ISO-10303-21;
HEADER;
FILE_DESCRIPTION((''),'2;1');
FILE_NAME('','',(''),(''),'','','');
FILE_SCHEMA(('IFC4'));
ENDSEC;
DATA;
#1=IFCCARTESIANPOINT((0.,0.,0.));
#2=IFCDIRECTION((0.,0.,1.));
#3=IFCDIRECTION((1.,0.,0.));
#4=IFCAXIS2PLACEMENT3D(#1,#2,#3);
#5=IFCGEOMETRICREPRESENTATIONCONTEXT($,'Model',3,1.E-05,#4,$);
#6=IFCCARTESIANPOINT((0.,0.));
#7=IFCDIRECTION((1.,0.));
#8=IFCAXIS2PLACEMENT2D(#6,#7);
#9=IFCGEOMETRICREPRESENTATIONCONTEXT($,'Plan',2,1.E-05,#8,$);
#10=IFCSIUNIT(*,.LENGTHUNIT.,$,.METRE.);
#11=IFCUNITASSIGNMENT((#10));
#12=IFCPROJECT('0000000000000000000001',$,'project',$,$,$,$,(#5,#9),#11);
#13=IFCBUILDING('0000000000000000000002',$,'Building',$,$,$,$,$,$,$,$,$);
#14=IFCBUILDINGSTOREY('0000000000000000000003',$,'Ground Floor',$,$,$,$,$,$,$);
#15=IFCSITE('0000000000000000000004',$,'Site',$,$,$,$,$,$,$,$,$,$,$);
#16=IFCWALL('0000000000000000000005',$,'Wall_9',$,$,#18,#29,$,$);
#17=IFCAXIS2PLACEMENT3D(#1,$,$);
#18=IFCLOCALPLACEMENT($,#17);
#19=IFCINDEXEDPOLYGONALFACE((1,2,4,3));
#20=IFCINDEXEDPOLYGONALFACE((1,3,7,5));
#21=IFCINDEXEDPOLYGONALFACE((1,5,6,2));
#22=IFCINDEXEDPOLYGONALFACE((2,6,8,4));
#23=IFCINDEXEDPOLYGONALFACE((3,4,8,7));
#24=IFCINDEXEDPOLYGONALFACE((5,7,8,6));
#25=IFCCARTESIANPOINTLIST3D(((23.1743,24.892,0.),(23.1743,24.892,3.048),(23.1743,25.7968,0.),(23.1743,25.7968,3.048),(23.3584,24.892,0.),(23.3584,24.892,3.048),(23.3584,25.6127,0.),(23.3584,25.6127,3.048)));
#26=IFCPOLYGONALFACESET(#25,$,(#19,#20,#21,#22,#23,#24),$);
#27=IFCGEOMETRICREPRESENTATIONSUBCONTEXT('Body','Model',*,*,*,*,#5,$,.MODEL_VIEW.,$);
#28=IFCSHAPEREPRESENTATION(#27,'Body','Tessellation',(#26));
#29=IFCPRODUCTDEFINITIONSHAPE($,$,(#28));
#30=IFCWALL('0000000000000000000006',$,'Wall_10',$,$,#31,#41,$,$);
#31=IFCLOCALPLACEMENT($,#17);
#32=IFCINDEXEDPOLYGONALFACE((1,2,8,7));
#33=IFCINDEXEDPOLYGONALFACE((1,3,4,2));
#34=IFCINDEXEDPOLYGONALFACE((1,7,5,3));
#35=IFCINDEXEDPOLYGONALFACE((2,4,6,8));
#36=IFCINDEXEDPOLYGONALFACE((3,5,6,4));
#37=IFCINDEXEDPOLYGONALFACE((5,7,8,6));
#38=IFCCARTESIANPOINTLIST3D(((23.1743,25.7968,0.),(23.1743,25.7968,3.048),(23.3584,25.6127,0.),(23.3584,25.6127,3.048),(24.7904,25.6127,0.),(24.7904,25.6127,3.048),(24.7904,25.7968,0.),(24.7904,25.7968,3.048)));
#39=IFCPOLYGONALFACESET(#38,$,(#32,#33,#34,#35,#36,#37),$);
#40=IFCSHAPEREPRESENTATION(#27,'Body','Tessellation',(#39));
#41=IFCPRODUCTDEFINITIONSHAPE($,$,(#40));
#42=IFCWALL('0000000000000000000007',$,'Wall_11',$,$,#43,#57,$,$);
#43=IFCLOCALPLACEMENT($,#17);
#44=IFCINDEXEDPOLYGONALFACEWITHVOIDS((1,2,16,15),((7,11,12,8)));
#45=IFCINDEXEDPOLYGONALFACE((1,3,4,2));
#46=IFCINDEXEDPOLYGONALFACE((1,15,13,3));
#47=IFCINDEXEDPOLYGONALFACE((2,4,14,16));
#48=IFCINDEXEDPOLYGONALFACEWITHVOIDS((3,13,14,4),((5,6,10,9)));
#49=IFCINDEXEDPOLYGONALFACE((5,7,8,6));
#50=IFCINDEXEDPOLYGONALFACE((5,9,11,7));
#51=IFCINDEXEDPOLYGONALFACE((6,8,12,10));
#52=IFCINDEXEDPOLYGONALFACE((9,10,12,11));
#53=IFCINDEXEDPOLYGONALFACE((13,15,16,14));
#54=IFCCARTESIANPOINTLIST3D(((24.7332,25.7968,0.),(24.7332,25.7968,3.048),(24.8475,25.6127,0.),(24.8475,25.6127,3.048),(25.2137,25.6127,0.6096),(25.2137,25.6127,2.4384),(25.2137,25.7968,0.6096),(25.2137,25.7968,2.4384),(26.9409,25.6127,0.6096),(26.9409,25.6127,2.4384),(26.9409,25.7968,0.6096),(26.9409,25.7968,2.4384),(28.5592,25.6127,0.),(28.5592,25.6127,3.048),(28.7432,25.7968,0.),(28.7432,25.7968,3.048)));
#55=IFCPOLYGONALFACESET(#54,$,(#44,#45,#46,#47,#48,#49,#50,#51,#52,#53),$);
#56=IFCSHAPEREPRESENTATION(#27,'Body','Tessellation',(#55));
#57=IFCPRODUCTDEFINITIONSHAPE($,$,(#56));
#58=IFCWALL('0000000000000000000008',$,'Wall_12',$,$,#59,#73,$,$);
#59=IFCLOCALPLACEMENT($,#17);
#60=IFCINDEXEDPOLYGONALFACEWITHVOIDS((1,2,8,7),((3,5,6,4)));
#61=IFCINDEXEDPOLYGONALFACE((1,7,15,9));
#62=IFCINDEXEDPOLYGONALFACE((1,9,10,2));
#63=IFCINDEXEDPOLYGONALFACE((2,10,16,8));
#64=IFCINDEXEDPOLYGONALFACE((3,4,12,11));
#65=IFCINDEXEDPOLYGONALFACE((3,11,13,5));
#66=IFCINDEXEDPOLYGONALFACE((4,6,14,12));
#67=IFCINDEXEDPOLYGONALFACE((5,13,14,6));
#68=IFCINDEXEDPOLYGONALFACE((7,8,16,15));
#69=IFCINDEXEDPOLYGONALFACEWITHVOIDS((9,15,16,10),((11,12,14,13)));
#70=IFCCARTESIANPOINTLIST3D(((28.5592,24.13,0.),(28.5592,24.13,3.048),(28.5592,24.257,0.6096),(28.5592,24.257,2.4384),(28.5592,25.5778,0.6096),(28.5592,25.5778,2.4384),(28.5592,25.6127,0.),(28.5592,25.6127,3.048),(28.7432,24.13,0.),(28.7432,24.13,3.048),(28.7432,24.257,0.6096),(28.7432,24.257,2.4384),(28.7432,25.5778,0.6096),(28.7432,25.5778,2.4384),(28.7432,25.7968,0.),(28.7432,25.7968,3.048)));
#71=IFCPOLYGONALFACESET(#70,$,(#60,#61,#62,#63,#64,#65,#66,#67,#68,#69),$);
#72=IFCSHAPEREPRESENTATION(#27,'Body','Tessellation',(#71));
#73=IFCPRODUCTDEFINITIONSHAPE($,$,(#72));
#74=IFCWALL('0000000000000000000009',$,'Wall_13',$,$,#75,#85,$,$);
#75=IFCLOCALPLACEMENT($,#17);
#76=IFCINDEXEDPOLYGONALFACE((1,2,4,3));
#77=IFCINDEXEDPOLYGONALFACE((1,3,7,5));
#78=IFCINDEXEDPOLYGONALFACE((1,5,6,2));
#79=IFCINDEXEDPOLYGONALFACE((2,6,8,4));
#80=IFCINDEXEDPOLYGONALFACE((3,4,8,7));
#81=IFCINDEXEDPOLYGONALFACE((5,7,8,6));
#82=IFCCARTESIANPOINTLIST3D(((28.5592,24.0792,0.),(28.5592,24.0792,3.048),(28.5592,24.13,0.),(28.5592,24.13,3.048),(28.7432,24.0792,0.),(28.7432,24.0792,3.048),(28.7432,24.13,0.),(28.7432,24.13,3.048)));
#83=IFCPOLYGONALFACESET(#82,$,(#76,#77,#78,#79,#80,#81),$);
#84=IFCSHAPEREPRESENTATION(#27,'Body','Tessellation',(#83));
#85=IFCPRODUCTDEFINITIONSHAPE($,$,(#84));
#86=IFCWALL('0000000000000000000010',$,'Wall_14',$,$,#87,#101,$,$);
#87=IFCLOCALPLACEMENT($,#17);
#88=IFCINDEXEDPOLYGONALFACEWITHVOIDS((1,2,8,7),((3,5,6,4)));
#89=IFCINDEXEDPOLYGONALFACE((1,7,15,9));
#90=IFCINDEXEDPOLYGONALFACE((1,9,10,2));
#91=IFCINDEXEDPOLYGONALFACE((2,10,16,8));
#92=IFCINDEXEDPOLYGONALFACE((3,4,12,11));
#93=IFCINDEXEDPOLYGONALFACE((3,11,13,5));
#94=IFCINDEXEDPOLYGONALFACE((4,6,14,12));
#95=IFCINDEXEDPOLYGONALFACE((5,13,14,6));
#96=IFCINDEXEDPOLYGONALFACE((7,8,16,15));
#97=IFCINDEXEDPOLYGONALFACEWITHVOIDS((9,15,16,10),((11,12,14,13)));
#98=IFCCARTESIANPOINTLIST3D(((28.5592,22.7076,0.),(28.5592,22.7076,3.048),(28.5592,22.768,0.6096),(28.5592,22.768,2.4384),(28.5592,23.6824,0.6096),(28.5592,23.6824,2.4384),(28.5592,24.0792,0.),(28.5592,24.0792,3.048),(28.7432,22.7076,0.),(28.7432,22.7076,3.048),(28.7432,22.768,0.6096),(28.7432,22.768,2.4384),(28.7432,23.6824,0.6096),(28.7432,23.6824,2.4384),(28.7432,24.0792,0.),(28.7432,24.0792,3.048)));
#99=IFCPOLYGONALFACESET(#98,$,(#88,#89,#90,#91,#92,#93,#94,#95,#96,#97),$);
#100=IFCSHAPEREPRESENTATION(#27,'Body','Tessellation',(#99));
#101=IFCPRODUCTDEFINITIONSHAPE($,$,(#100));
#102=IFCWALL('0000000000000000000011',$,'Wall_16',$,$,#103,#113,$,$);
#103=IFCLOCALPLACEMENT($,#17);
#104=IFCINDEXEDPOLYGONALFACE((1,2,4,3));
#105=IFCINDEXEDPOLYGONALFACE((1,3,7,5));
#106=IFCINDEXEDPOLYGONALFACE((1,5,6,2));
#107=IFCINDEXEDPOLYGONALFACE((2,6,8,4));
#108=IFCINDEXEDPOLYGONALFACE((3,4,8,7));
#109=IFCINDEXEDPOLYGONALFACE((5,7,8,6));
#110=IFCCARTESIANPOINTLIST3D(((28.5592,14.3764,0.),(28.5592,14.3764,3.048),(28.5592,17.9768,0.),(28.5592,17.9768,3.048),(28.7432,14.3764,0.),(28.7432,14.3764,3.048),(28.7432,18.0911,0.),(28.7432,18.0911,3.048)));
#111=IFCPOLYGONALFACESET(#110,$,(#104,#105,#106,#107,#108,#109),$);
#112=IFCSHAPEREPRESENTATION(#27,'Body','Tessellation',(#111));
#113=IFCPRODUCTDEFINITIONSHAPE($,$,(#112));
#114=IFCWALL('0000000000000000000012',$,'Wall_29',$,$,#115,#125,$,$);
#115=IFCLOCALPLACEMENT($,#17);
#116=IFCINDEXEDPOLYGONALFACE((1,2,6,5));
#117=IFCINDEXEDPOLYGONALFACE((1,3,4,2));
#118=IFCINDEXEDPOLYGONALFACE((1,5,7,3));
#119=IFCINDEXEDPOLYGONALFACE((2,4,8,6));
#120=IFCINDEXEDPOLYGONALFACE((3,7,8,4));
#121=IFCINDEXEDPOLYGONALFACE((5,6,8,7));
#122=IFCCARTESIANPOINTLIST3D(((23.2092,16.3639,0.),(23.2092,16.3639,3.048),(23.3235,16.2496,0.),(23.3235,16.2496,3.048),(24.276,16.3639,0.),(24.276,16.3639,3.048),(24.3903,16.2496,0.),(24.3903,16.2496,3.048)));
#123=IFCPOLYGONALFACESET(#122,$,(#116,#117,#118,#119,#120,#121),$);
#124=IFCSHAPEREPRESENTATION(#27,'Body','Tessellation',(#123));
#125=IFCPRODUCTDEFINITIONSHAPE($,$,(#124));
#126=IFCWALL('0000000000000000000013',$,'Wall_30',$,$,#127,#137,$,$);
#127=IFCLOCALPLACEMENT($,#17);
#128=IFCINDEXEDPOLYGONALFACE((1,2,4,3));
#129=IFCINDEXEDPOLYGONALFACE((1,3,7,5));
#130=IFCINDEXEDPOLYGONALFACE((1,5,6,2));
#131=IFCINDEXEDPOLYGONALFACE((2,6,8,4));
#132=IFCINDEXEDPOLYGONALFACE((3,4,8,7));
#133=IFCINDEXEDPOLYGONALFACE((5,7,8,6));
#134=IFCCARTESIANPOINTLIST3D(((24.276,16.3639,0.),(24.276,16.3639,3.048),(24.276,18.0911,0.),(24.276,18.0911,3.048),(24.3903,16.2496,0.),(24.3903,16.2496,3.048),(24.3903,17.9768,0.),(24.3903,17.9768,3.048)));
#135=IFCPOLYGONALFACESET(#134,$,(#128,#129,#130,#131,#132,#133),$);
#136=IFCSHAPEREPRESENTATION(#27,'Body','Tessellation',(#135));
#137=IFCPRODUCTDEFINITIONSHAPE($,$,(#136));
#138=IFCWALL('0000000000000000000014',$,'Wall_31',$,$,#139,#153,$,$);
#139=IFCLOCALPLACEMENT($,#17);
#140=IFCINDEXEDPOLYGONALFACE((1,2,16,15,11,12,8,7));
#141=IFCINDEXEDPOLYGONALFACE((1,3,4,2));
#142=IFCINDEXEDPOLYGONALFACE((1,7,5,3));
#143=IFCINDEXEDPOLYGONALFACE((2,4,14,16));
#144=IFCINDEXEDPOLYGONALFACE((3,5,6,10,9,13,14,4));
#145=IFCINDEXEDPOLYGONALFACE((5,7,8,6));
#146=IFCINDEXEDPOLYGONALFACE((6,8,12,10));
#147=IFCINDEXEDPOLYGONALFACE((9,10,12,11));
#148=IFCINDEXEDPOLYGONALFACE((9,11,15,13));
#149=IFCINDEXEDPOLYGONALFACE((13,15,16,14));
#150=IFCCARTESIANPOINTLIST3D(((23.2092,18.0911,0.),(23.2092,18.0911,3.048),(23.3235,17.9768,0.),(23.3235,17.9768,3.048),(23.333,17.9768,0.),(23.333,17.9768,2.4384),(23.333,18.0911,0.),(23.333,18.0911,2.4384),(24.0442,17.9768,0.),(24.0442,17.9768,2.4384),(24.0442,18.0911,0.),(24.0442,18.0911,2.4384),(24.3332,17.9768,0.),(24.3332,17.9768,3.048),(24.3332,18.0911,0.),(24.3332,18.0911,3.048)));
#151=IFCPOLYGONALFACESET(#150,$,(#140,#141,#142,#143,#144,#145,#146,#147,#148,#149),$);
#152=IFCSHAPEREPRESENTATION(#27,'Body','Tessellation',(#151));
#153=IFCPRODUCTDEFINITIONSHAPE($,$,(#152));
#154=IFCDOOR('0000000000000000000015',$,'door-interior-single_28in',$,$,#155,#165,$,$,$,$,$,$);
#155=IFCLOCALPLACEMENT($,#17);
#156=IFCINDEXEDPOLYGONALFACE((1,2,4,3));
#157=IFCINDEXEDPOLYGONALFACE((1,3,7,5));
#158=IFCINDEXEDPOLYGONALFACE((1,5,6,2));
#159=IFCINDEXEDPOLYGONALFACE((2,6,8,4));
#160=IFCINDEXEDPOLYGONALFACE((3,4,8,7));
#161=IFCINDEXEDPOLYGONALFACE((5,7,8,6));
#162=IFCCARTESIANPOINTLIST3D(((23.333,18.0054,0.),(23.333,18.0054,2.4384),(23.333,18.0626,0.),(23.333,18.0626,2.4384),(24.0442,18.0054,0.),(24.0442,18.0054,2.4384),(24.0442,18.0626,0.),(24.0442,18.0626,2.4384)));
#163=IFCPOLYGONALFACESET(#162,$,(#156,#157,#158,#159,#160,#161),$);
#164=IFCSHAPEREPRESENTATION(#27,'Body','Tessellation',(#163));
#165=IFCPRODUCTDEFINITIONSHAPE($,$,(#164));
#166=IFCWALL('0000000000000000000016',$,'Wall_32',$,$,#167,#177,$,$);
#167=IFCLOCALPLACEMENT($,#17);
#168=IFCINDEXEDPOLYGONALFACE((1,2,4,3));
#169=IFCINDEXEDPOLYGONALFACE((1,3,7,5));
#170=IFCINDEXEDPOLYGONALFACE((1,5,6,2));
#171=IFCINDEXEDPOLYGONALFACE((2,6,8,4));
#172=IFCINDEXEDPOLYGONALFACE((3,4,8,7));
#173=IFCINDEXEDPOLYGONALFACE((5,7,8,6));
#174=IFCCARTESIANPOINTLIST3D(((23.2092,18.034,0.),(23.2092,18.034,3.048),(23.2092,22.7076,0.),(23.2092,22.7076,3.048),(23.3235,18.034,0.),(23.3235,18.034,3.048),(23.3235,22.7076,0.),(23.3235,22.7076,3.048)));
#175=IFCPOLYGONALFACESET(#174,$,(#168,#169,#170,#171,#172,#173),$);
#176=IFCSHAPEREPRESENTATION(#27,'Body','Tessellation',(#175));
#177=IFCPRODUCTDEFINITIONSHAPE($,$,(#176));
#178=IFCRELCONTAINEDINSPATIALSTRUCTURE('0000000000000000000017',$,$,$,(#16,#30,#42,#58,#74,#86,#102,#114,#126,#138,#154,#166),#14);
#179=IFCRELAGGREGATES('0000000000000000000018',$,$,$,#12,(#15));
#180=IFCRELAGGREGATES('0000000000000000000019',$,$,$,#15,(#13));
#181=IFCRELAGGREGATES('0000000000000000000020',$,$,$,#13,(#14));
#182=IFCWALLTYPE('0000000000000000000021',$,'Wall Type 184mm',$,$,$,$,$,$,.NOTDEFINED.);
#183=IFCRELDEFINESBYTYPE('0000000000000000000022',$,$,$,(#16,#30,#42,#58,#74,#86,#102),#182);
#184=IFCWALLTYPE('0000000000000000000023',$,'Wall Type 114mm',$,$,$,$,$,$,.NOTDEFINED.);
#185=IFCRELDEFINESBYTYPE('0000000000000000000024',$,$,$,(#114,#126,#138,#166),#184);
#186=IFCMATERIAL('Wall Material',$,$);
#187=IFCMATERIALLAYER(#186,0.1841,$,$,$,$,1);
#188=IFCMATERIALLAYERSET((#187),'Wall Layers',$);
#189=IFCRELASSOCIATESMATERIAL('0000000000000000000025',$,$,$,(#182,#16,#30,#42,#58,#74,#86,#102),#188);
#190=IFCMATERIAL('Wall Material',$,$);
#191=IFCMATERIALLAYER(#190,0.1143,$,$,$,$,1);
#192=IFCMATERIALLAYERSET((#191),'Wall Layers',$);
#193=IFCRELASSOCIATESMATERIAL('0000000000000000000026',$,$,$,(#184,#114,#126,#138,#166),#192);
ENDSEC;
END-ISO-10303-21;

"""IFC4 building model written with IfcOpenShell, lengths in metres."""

from ifc_helpers import new_model, si_unit, frame, origin_with_axes, origin_2d_with_axis, place, context, subcontext, project, spatial, line, indexed_curve, rectangle, outline, extrude, material, layer, layer_set, layer_usage, type_object, element, fill, save


model = new_model("IFC4")

# Units and contexts
model_context = context("Model", 3, precision=1e-05, world=origin_with_axes())
plan_context = context("Plan", 2, precision=1e-05, world=origin_2d_with_axis())
body_context = subcontext(model_context, "Body", "Model", "MODEL_VIEW")
ifc_project = project(units=[si_unit("LENGTHUNIT", "METRE")], contexts=[model_context, plan_context])

# Site, building, storey
site = spatial("IfcSite", under=ifc_project, Name="Site")
building = spatial("IfcBuilding", under=site, Name="Building")
storey = spatial("IfcBuildingStorey", under=building, Name="Ground Floor")

# Walls
ifc_material_1 = material(Name="Wall Material")
ifc_layer_1 = layer(ifc_material_1, 0.1841, Priority=1)
ifc_layer_set_1 = layer_set([ifc_layer_1], Name="Wall Layers")
ifc_layer_usage_1 = layer_usage(ifc_layer_set_1, "AXIS2", "POSITIVE", -0.0921)
wall_type_1 = type_object("IfcWallType", Name="Wall Type 184mm", PredefinedType="NOTDEFINED", material=ifc_layer_set_1)
wall_1_placement = place(None, frame((23.2664, 24.892, 0.0), z_axis=(0.0, 0.0, 1.0), x_axis=(0.0, 1.0, 0.0)))
element("IfcWall", 1, at=wall_1_placement, inside=storey, type_object=wall_type_1, material=ifc_layer_usage_1, Name="Wall_9", context=body_context, shape_type="SweptSolid", body=[
    extrude(outline(indexed_curve([(0.0, -0.0921), (0.0, 0.0921), (0.9048, 0.0921), (0.7207, -0.0921)], segments=[line(1, 2, 3, 4, 1)])), origin_with_axes(), (0.0, 0.0, 1.0), 3.048),
])
ifc_layer_usage_2 = layer_usage(ifc_layer_set_1, "AXIS2", "POSITIVE", -0.0921)
wall_2_placement = place(None, frame((23.2664, 25.7048, 0.0), z_axis=(0.0, 0.0, 1.0), x_axis=(1.0, 0.0, 0.0)))
element("IfcWall", 2, at=wall_2_placement, inside=storey, type_object=wall_type_1, material=ifc_layer_usage_2, Name="Wall_10", context=body_context, shape_type="SweptSolid", body=[
    extrude(outline(indexed_curve([(0.0921, -0.0921), (-0.0921, 0.0921), (1.524, 0.0921), (1.524, -0.0921)], segments=[line(1, 2, 3, 4, 1)])), origin_with_axes(), (0.0, 0.0, 1.0), 3.048),
])

# Walls, openings
ifc_layer_usage_3 = layer_usage(ifc_layer_set_1, "AXIS2", "POSITIVE", -0.0921)
wall_3_placement = place(None, frame((24.7904, 25.7048, 0.0), z_axis=(0.0, 0.0, 1.0), x_axis=(1.0, 0.0, 0.0)))
wall_3 = element("IfcWall", 3, at=wall_3_placement, inside=storey, type_object=wall_type_1, material=ifc_layer_usage_3, Name="Wall_11", context=body_context, shape_type="SweptSolid", body=[
    extrude(outline(indexed_curve([(0.0571, -0.0921), (-0.0571, 0.0921), (3.9529, 0.0921), (3.7688, -0.0921)], segments=[line(1, 2, 3, 4, 1)])), origin_with_axes(), (0.0, 0.0, 1.0), 3.048),
])
opening_1_placement = place(wall_3_placement, frame((1.2869, 0.0, 0.6096), z_axis=(0.0, 0.0, 1.0), x_axis=(1.0, 0.0, 0.0)))
element("IfcOpeningElement", 4, at=opening_1_placement, cuts=wall_3, context=body_context, shape_type="SweptSolid", body=[
    extrude(rectangle(XDim=1.7272, YDim=0.5524), None, (0.0, 0.0, 1.0), 1.8288),
])
ifc_layer_usage_4 = layer_usage(ifc_layer_set_1, "AXIS2", "POSITIVE", -0.0921)
wall_4_placement = place(None, frame((28.6512, 25.7048, 0.0), z_axis=(0.0, 0.0, 1.0), x_axis=(0.0, -1.0, 0.0)))
wall_4 = element("IfcWall", 5, at=wall_4_placement, inside=storey, type_object=wall_type_1, material=ifc_layer_usage_4, Name="Wall_12", context=body_context, shape_type="SweptSolid", body=[
    extrude(outline(indexed_curve([(0.0921, -0.0921), (-0.0921, 0.0921), (1.5748, 0.0921), (1.5748, -0.0921)], segments=[line(1, 2, 3, 4, 1)])), origin_with_axes(), (0.0, 0.0, 1.0), 3.048),
])
opening_2_placement = place(wall_4_placement, frame((0.7874, 0.0, 0.6096), z_axis=(0.0, 0.0, 1.0), x_axis=(1.0, 0.0, 0.0)))
element("IfcOpeningElement", 6, at=opening_2_placement, cuts=wall_4, context=body_context, shape_type="SweptSolid", body=[
    extrude(rectangle(XDim=1.3208, YDim=0.5524), None, (0.0, 0.0, 1.0), 1.8288),
])

# Wall
ifc_layer_usage_5 = layer_usage(ifc_layer_set_1, "AXIS2", "POSITIVE", -0.0921)
wall_5_placement = place(None, frame((28.6512, 24.13, 0.0), z_axis=(0.0, 0.0, 1.0), x_axis=(0.0, -1.0, 0.0)))
element("IfcWall", 7, at=wall_5_placement, inside=storey, type_object=wall_type_1, material=ifc_layer_usage_5, Name="Wall_13", context=body_context, shape_type="SweptSolid", body=[
    extrude(outline(indexed_curve([(0.0, -0.0921), (0.0, 0.0921), (0.0508, 0.0921), (0.0508, -0.0921)], segments=[line(1, 2, 3, 4, 1)])), origin_with_axes(), (0.0, 0.0, 1.0), 3.048),
])

# Wall, opening
ifc_layer_usage_6 = layer_usage(ifc_layer_set_1, "AXIS2", "POSITIVE", -0.0921)
wall_6_placement = place(None, frame((28.6512, 24.0792, 0.0), z_axis=(0.0, 0.0, 1.0), x_axis=(0.0, -1.0, 0.0)))
wall_6 = element("IfcWall", 8, at=wall_6_placement, inside=storey, type_object=wall_type_1, material=ifc_layer_usage_6, Name="Wall_14", context=body_context, shape_type="SweptSolid", body=[
    extrude(outline(indexed_curve([(0.0, -0.0921), (0.0, 0.0921), (1.3716, 0.0921), (1.3716, -0.0921)], segments=[line(1, 2, 3, 4, 1)])), origin_with_axes(), (0.0, 0.0, 1.0), 3.048),
])
opening_3_placement = place(wall_6_placement, frame((0.854, 0.0, 0.6096), z_axis=(0.0, 0.0, 1.0), x_axis=(1.0, 0.0, 0.0)))
element("IfcOpeningElement", 9, at=opening_3_placement, cuts=wall_6, context=body_context, shape_type="SweptSolid", body=[
    extrude(rectangle(XDim=0.9144, YDim=0.5524), None, (0.0, 0.0, 1.0), 1.8288),
])

# Walls
ifc_layer_usage_7 = layer_usage(ifc_layer_set_1, "AXIS2", "POSITIVE", -0.0921)
wall_7_placement = place(None, frame((28.6512, 18.034, 0.0), z_axis=(0.0, 0.0, 1.0), x_axis=(0.0, -1.0, 0.0)))
element("IfcWall", 10, at=wall_7_placement, inside=storey, type_object=wall_type_1, material=ifc_layer_usage_7, Name="Wall_16", context=body_context, shape_type="SweptSolid", body=[
    extrude(outline(indexed_curve([(0.0571, -0.0921), (-0.0571, 0.0921), (3.6576, 0.0921), (3.6576, -0.0921)], segments=[line(1, 2, 3, 4, 1)])), origin_with_axes(), (0.0, 0.0, 1.0), 3.048),
])
ifc_material_2 = material(Name="Wall Material")
ifc_layer_2 = layer(ifc_material_2, 0.1143, Priority=1)
ifc_layer_set_2 = layer_set([ifc_layer_2], Name="Wall Layers")
ifc_layer_usage_8 = layer_usage(ifc_layer_set_2, "AXIS2", "POSITIVE", -0.0571)
wall_type_2 = type_object("IfcWallType", Name="Wall Type 114mm", PredefinedType="NOTDEFINED", material=ifc_layer_set_2)
wall_8_placement = place(None, frame((23.2664, 16.3068, 0.0), z_axis=(0.0, 0.0, 1.0), x_axis=(1.0, 0.0, 0.0)))
element("IfcWall", 11, at=wall_8_placement, inside=storey, type_object=wall_type_2, material=ifc_layer_usage_8, Name="Wall_29", context=body_context, shape_type="SweptSolid", body=[
    extrude(outline(indexed_curve([(0.0571, -0.0571), (-0.0571, 0.0571), (1.0097, 0.0571), (1.124, -0.0571)], segments=[line(1, 2, 3, 4, 1)])), origin_with_axes(), (0.0, 0.0, 1.0), 3.048),
])
ifc_layer_usage_9 = layer_usage(ifc_layer_set_2, "AXIS2", "POSITIVE", -0.0571)
wall_9_placement = place(None, frame((24.3332, 16.3068, 0.0), z_axis=(0.0, 0.0, 1.0), x_axis=(0.0, 1.0, 0.0)))
element("IfcWall", 12, at=wall_9_placement, inside=storey, type_object=wall_type_2, material=ifc_layer_usage_9, Name="Wall_30", context=body_context, shape_type="SweptSolid", body=[
    extrude(outline(indexed_curve([(-0.0571, -0.0571), (0.0571, 0.0571), (1.7843, 0.0571), (1.67, -0.0571)], segments=[line(1, 2, 3, 4, 1)])), origin_with_axes(), (0.0, 0.0, 1.0), 3.048),
])

# Wall, opening, door
ifc_layer_usage_10 = layer_usage(ifc_layer_set_2, "AXIS2", "POSITIVE", -0.0571)
wall_10_placement = place(None, frame((24.3332, 18.034, 0.0), z_axis=(0.0, 0.0, 1.0), x_axis=(-1.0, 0.0, 0.0)))
wall_10 = element("IfcWall", 13, at=wall_10_placement, inside=storey, type_object=wall_type_2, material=ifc_layer_usage_10, Name="Wall_31", context=body_context, shape_type="SweptSolid", body=[
    extrude(outline(indexed_curve([(0.0, -0.0571), (0.0, 0.0571), (1.0097, 0.0571), (1.124, -0.0571)], segments=[line(1, 2, 3, 4, 1)])), origin_with_axes(), (0.0, 0.0, 1.0), 3.048),
])
opening_4_placement = place(wall_10_placement, frame((0.6446, 0.0, 0.0), z_axis=(0.0, 0.0, 1.0), x_axis=(1.0, 0.0, 0.0)))
opening_4 = element("IfcOpeningElement", 14, at=opening_4_placement, cuts=wall_10, context=body_context, shape_type="SweptSolid", body=[
    extrude(rectangle(XDim=0.7112, YDim=0.5), None, (0.0, 0.0, 1.0), 2.4384),
])
door_1_placement = place(None, frame((23.6886, 18.034, 0.0), z_axis=(0.0, 0.0, 1.0), x_axis=(1.0, 0.0, 0.0)))
door_1 = element("IfcDoor", 15, at=door_1_placement, inside=storey, Name="door-interior-single_28in", context=body_context, shape_type="SweptSolid", body=[
    extrude(rectangle(XDim=0.7112, YDim=0.0571), None, (0.0, 0.0, 1.0), 2.4384),
])
fill(opening_4, door_1)

# Wall
ifc_layer_usage_11 = layer_usage(ifc_layer_set_2, "AXIS2", "POSITIVE", -0.0571)
wall_11_placement = place(None, frame((23.2664, 18.034, 0.0), z_axis=(0.0, 0.0, 1.0), x_axis=(0.0, 1.0, 0.0)))
element("IfcWall", 16, at=wall_11_placement, inside=storey, type_object=wall_type_2, material=ifc_layer_usage_11, Name="Wall_32", context=body_context, shape_type="SweptSolid", body=[
    extrude(outline(indexed_curve([(0.0, -0.0571), (0.0, 0.0571), (4.6736, 0.0571), (4.6736, -0.0571)], segments=[line(1, 2, 3, 4, 1)])), origin_with_axes(), (0.0, 0.0, 1.0), 3.048),
])

save(model, "model.ifc")
